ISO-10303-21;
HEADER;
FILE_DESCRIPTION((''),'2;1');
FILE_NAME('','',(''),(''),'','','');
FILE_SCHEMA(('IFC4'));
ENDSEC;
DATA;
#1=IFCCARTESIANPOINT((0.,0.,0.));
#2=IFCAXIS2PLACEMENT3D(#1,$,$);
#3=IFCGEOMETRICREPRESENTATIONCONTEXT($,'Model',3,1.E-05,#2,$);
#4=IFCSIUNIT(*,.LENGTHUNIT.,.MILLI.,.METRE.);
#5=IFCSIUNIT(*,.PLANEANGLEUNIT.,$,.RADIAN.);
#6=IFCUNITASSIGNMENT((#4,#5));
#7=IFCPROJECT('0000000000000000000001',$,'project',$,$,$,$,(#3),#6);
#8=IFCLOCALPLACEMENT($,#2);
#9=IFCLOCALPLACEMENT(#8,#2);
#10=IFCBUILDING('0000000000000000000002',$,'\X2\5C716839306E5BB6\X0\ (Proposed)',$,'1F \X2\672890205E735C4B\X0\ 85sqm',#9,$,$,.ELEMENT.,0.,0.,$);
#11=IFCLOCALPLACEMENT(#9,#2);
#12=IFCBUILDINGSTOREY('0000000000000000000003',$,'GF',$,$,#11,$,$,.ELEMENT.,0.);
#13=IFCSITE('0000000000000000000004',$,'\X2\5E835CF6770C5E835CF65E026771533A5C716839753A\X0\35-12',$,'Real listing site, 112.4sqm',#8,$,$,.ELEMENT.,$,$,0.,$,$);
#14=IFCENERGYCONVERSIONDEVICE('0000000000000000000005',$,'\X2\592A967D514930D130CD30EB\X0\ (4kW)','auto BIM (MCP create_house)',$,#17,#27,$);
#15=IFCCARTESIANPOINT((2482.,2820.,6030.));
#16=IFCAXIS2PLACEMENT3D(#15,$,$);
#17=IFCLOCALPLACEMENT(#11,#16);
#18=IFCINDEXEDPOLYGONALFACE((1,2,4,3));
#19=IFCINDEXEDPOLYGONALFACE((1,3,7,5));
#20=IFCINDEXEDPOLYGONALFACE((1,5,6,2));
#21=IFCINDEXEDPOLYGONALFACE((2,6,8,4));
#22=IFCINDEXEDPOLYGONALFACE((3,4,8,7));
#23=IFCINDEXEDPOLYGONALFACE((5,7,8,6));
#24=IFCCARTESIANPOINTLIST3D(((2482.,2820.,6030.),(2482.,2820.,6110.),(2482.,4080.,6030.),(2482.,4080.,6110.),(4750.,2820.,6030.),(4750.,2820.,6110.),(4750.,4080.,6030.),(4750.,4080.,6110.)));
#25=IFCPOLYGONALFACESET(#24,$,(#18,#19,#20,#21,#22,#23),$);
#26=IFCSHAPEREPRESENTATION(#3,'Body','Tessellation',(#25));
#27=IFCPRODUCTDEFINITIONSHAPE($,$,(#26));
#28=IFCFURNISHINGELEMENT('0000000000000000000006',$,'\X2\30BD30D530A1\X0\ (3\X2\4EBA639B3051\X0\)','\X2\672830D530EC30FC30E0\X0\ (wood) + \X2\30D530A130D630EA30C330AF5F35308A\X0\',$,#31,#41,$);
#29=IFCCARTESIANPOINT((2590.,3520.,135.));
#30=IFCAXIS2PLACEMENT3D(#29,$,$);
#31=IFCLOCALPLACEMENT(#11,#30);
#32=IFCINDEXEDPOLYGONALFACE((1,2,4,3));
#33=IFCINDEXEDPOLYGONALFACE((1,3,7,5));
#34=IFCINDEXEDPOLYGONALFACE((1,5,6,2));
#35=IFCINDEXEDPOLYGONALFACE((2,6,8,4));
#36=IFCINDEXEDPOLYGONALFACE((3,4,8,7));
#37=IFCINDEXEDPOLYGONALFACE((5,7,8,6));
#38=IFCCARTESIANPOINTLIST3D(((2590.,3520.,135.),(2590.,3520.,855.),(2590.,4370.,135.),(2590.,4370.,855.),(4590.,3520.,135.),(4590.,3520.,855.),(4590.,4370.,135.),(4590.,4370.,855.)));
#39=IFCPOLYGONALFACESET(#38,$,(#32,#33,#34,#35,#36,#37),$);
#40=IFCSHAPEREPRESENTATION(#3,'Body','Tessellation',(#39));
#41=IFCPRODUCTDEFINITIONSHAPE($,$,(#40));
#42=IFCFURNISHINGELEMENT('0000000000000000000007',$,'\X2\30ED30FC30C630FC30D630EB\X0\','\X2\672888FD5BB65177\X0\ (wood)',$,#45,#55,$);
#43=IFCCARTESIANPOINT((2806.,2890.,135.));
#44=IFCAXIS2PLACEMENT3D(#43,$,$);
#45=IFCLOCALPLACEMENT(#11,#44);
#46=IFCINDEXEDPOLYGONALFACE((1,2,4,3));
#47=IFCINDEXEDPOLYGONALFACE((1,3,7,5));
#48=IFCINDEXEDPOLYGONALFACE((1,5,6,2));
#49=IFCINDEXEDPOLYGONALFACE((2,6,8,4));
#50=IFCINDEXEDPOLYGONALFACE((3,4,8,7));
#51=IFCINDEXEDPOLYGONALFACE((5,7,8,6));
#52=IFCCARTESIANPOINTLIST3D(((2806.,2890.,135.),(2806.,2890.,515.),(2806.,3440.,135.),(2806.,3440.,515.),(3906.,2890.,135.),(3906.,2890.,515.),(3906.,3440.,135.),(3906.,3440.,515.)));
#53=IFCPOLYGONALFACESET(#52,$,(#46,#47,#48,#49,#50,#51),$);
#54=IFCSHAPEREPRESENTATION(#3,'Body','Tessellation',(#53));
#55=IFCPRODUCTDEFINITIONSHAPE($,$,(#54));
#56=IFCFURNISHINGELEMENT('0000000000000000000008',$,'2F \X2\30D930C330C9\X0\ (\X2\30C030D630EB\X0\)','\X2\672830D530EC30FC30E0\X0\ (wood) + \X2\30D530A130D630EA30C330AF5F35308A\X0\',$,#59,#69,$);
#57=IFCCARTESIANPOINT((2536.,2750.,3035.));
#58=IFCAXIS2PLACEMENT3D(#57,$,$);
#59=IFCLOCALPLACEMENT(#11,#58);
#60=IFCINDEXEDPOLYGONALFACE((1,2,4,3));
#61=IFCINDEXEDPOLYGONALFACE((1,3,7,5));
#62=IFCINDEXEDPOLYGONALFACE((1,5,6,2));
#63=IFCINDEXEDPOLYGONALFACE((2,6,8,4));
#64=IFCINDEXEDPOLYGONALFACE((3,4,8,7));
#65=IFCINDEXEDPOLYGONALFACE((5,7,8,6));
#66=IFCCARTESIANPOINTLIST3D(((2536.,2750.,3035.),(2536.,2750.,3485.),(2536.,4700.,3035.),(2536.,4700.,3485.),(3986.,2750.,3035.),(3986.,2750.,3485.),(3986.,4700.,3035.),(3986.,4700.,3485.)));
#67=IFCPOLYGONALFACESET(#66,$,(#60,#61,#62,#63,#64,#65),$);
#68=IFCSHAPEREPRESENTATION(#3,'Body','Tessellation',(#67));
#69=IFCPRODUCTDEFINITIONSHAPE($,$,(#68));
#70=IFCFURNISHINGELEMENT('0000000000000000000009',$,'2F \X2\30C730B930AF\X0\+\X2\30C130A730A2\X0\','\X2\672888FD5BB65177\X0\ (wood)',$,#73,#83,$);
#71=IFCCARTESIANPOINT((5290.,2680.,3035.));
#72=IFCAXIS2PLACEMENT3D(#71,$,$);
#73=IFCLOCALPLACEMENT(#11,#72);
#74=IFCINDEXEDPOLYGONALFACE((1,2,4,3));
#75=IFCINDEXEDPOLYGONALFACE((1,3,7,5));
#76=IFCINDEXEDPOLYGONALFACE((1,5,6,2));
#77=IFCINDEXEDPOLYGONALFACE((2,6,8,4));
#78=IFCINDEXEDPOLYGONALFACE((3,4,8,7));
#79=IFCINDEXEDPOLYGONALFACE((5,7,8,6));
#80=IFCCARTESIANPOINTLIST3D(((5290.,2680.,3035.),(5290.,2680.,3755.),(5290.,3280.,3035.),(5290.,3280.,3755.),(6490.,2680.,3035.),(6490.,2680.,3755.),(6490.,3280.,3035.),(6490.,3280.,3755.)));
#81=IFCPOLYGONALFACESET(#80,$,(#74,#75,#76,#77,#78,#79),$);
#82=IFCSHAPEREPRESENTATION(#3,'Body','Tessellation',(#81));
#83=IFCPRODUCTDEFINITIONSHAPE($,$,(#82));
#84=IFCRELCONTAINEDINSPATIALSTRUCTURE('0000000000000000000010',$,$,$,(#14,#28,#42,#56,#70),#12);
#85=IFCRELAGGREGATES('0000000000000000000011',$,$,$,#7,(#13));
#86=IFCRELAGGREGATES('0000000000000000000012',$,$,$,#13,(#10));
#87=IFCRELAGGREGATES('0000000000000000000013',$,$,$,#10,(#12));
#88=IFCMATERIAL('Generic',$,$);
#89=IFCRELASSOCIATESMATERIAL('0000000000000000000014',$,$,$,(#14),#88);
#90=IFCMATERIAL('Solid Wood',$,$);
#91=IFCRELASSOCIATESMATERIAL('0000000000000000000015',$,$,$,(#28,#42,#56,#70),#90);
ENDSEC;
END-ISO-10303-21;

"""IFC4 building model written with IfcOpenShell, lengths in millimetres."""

from ifc_helpers import new_model, si_unit, frame, frame_2d, origin, place, context, project, spatial, rectangle, extrude, material, element, save


model = new_model("IFC4")

# Units and contexts
model_context = context("Model", 3, precision=1e-05, world=origin())
ifc_project = project(units=[si_unit("LENGTHUNIT", "METRE", prefix="MILLI"), si_unit("PLANEANGLEUNIT", "RADIAN")], contexts=[model_context])

# Site, building, storey
site_placement = place(None, origin())
site = spatial("IfcSite", under=ifc_project, at=site_placement, Name="広島県広島市東区山根町35-12", ObjectType="Real listing site, 112.4sqm", CompositionType="ELEMENT", RefElevation=0.0)
building_placement = place(site_placement, origin())
building = spatial("IfcBuilding", under=site, at=building_placement, Name="山根の家 (Proposed)", ObjectType="1F 木造平屋 85sqm", CompositionType="ELEMENT", ElevationOfRefHeight=0.0, ElevationOfTerrain=0.0)
storey_placement = place(building_placement, origin())
storey = spatial("IfcBuildingStorey", under=building, at=storey_placement, Name="GF", CompositionType="ELEMENT", Elevation=0.0)

# Shared definitions
ifc_material_1 = material(Name="Solid Wood")

# Shared definitions
ifc_material_2 = material(Name="Generic")

# Energy conversion device
energy_conversion_device_placement = place(storey_placement, frame((2482.0, 2820.0, 6030.0)))
element("IfcEnergyConversionDevice", 1, at=energy_conversion_device_placement, inside=storey, material=ifc_material_2, Name="太陽光パネル (4kW)", Description="auto BIM (MCP create_house)", context=model_context, shape_type="SweptSolid", body=[
    extrude(rectangle(XDim=2268.0, YDim=1260.0, at=frame_2d((1134.0, 630.0))), frame((2482.0, 2820.0, 6030.0)), (0.0, 0.0, 1.0), 80.0),
])

# Furnishing elements
furnishing_1_placement = place(storey_placement, frame((2590.0, 3520.0, 135.0)))
element("IfcFurnishingElement", 2, at=furnishing_1_placement, inside=storey, material=ifc_material_1, Name="ソファ (3人掛け)", Description="木フレーム (wood) + ファブリック張り", context=model_context, shape_type="SweptSolid", body=[
    extrude(rectangle(XDim=2000.0, YDim=850.0, at=frame_2d((1000.0, 425.0))), frame((2590.0, 3520.0, 135.0)), (0.0, 0.0, 1.0), 720.0),
])
furnishing_2_placement = place(storey_placement, frame((2806.0, 2890.0, 135.0)))
element("IfcFurnishingElement", 3, at=furnishing_2_placement, inside=storey, material=ifc_material_1, Name="ローテーブル", Description="木製家具 (wood)", context=model_context, shape_type="SweptSolid", body=[
    extrude(rectangle(XDim=1100.0, YDim=550.0, at=frame_2d((550.0, 275.0))), frame((2806.0, 2890.0, 135.0)), (0.0, 0.0, 1.0), 380.0),
])
furnishing_3_placement = place(storey_placement, frame((2536.0, 2750.0, 3035.0)))
element("IfcFurnishingElement", 4, at=furnishing_3_placement, inside=storey, material=ifc_material_1, Name="2F ベッド (ダブル)", Description="木フレーム (wood) + ファブリック張り", context=model_context, shape_type="SweptSolid", body=[
    extrude(rectangle(XDim=1450.0, YDim=1950.0, at=frame_2d((725.0, 975.0))), frame((2536.0, 2750.0, 3035.0)), (0.0, 0.0, 1.0), 450.0),
])
furnishing_4_placement = place(storey_placement, frame((5290.0, 2680.0, 3035.0)))
element("IfcFurnishingElement", 5, at=furnishing_4_placement, inside=storey, material=ifc_material_1, Name="2F デスク+チェア", Description="木製家具 (wood)", context=model_context, shape_type="SweptSolid", body=[
    extrude(rectangle(XDim=1200.0, YDim=600.0, at=frame_2d((600.0, 300.0))), frame((5290.0, 2680.0, 3035.0)), (0.0, 0.0, 1.0), 720.0),
])

save(model, "model.ifc")
